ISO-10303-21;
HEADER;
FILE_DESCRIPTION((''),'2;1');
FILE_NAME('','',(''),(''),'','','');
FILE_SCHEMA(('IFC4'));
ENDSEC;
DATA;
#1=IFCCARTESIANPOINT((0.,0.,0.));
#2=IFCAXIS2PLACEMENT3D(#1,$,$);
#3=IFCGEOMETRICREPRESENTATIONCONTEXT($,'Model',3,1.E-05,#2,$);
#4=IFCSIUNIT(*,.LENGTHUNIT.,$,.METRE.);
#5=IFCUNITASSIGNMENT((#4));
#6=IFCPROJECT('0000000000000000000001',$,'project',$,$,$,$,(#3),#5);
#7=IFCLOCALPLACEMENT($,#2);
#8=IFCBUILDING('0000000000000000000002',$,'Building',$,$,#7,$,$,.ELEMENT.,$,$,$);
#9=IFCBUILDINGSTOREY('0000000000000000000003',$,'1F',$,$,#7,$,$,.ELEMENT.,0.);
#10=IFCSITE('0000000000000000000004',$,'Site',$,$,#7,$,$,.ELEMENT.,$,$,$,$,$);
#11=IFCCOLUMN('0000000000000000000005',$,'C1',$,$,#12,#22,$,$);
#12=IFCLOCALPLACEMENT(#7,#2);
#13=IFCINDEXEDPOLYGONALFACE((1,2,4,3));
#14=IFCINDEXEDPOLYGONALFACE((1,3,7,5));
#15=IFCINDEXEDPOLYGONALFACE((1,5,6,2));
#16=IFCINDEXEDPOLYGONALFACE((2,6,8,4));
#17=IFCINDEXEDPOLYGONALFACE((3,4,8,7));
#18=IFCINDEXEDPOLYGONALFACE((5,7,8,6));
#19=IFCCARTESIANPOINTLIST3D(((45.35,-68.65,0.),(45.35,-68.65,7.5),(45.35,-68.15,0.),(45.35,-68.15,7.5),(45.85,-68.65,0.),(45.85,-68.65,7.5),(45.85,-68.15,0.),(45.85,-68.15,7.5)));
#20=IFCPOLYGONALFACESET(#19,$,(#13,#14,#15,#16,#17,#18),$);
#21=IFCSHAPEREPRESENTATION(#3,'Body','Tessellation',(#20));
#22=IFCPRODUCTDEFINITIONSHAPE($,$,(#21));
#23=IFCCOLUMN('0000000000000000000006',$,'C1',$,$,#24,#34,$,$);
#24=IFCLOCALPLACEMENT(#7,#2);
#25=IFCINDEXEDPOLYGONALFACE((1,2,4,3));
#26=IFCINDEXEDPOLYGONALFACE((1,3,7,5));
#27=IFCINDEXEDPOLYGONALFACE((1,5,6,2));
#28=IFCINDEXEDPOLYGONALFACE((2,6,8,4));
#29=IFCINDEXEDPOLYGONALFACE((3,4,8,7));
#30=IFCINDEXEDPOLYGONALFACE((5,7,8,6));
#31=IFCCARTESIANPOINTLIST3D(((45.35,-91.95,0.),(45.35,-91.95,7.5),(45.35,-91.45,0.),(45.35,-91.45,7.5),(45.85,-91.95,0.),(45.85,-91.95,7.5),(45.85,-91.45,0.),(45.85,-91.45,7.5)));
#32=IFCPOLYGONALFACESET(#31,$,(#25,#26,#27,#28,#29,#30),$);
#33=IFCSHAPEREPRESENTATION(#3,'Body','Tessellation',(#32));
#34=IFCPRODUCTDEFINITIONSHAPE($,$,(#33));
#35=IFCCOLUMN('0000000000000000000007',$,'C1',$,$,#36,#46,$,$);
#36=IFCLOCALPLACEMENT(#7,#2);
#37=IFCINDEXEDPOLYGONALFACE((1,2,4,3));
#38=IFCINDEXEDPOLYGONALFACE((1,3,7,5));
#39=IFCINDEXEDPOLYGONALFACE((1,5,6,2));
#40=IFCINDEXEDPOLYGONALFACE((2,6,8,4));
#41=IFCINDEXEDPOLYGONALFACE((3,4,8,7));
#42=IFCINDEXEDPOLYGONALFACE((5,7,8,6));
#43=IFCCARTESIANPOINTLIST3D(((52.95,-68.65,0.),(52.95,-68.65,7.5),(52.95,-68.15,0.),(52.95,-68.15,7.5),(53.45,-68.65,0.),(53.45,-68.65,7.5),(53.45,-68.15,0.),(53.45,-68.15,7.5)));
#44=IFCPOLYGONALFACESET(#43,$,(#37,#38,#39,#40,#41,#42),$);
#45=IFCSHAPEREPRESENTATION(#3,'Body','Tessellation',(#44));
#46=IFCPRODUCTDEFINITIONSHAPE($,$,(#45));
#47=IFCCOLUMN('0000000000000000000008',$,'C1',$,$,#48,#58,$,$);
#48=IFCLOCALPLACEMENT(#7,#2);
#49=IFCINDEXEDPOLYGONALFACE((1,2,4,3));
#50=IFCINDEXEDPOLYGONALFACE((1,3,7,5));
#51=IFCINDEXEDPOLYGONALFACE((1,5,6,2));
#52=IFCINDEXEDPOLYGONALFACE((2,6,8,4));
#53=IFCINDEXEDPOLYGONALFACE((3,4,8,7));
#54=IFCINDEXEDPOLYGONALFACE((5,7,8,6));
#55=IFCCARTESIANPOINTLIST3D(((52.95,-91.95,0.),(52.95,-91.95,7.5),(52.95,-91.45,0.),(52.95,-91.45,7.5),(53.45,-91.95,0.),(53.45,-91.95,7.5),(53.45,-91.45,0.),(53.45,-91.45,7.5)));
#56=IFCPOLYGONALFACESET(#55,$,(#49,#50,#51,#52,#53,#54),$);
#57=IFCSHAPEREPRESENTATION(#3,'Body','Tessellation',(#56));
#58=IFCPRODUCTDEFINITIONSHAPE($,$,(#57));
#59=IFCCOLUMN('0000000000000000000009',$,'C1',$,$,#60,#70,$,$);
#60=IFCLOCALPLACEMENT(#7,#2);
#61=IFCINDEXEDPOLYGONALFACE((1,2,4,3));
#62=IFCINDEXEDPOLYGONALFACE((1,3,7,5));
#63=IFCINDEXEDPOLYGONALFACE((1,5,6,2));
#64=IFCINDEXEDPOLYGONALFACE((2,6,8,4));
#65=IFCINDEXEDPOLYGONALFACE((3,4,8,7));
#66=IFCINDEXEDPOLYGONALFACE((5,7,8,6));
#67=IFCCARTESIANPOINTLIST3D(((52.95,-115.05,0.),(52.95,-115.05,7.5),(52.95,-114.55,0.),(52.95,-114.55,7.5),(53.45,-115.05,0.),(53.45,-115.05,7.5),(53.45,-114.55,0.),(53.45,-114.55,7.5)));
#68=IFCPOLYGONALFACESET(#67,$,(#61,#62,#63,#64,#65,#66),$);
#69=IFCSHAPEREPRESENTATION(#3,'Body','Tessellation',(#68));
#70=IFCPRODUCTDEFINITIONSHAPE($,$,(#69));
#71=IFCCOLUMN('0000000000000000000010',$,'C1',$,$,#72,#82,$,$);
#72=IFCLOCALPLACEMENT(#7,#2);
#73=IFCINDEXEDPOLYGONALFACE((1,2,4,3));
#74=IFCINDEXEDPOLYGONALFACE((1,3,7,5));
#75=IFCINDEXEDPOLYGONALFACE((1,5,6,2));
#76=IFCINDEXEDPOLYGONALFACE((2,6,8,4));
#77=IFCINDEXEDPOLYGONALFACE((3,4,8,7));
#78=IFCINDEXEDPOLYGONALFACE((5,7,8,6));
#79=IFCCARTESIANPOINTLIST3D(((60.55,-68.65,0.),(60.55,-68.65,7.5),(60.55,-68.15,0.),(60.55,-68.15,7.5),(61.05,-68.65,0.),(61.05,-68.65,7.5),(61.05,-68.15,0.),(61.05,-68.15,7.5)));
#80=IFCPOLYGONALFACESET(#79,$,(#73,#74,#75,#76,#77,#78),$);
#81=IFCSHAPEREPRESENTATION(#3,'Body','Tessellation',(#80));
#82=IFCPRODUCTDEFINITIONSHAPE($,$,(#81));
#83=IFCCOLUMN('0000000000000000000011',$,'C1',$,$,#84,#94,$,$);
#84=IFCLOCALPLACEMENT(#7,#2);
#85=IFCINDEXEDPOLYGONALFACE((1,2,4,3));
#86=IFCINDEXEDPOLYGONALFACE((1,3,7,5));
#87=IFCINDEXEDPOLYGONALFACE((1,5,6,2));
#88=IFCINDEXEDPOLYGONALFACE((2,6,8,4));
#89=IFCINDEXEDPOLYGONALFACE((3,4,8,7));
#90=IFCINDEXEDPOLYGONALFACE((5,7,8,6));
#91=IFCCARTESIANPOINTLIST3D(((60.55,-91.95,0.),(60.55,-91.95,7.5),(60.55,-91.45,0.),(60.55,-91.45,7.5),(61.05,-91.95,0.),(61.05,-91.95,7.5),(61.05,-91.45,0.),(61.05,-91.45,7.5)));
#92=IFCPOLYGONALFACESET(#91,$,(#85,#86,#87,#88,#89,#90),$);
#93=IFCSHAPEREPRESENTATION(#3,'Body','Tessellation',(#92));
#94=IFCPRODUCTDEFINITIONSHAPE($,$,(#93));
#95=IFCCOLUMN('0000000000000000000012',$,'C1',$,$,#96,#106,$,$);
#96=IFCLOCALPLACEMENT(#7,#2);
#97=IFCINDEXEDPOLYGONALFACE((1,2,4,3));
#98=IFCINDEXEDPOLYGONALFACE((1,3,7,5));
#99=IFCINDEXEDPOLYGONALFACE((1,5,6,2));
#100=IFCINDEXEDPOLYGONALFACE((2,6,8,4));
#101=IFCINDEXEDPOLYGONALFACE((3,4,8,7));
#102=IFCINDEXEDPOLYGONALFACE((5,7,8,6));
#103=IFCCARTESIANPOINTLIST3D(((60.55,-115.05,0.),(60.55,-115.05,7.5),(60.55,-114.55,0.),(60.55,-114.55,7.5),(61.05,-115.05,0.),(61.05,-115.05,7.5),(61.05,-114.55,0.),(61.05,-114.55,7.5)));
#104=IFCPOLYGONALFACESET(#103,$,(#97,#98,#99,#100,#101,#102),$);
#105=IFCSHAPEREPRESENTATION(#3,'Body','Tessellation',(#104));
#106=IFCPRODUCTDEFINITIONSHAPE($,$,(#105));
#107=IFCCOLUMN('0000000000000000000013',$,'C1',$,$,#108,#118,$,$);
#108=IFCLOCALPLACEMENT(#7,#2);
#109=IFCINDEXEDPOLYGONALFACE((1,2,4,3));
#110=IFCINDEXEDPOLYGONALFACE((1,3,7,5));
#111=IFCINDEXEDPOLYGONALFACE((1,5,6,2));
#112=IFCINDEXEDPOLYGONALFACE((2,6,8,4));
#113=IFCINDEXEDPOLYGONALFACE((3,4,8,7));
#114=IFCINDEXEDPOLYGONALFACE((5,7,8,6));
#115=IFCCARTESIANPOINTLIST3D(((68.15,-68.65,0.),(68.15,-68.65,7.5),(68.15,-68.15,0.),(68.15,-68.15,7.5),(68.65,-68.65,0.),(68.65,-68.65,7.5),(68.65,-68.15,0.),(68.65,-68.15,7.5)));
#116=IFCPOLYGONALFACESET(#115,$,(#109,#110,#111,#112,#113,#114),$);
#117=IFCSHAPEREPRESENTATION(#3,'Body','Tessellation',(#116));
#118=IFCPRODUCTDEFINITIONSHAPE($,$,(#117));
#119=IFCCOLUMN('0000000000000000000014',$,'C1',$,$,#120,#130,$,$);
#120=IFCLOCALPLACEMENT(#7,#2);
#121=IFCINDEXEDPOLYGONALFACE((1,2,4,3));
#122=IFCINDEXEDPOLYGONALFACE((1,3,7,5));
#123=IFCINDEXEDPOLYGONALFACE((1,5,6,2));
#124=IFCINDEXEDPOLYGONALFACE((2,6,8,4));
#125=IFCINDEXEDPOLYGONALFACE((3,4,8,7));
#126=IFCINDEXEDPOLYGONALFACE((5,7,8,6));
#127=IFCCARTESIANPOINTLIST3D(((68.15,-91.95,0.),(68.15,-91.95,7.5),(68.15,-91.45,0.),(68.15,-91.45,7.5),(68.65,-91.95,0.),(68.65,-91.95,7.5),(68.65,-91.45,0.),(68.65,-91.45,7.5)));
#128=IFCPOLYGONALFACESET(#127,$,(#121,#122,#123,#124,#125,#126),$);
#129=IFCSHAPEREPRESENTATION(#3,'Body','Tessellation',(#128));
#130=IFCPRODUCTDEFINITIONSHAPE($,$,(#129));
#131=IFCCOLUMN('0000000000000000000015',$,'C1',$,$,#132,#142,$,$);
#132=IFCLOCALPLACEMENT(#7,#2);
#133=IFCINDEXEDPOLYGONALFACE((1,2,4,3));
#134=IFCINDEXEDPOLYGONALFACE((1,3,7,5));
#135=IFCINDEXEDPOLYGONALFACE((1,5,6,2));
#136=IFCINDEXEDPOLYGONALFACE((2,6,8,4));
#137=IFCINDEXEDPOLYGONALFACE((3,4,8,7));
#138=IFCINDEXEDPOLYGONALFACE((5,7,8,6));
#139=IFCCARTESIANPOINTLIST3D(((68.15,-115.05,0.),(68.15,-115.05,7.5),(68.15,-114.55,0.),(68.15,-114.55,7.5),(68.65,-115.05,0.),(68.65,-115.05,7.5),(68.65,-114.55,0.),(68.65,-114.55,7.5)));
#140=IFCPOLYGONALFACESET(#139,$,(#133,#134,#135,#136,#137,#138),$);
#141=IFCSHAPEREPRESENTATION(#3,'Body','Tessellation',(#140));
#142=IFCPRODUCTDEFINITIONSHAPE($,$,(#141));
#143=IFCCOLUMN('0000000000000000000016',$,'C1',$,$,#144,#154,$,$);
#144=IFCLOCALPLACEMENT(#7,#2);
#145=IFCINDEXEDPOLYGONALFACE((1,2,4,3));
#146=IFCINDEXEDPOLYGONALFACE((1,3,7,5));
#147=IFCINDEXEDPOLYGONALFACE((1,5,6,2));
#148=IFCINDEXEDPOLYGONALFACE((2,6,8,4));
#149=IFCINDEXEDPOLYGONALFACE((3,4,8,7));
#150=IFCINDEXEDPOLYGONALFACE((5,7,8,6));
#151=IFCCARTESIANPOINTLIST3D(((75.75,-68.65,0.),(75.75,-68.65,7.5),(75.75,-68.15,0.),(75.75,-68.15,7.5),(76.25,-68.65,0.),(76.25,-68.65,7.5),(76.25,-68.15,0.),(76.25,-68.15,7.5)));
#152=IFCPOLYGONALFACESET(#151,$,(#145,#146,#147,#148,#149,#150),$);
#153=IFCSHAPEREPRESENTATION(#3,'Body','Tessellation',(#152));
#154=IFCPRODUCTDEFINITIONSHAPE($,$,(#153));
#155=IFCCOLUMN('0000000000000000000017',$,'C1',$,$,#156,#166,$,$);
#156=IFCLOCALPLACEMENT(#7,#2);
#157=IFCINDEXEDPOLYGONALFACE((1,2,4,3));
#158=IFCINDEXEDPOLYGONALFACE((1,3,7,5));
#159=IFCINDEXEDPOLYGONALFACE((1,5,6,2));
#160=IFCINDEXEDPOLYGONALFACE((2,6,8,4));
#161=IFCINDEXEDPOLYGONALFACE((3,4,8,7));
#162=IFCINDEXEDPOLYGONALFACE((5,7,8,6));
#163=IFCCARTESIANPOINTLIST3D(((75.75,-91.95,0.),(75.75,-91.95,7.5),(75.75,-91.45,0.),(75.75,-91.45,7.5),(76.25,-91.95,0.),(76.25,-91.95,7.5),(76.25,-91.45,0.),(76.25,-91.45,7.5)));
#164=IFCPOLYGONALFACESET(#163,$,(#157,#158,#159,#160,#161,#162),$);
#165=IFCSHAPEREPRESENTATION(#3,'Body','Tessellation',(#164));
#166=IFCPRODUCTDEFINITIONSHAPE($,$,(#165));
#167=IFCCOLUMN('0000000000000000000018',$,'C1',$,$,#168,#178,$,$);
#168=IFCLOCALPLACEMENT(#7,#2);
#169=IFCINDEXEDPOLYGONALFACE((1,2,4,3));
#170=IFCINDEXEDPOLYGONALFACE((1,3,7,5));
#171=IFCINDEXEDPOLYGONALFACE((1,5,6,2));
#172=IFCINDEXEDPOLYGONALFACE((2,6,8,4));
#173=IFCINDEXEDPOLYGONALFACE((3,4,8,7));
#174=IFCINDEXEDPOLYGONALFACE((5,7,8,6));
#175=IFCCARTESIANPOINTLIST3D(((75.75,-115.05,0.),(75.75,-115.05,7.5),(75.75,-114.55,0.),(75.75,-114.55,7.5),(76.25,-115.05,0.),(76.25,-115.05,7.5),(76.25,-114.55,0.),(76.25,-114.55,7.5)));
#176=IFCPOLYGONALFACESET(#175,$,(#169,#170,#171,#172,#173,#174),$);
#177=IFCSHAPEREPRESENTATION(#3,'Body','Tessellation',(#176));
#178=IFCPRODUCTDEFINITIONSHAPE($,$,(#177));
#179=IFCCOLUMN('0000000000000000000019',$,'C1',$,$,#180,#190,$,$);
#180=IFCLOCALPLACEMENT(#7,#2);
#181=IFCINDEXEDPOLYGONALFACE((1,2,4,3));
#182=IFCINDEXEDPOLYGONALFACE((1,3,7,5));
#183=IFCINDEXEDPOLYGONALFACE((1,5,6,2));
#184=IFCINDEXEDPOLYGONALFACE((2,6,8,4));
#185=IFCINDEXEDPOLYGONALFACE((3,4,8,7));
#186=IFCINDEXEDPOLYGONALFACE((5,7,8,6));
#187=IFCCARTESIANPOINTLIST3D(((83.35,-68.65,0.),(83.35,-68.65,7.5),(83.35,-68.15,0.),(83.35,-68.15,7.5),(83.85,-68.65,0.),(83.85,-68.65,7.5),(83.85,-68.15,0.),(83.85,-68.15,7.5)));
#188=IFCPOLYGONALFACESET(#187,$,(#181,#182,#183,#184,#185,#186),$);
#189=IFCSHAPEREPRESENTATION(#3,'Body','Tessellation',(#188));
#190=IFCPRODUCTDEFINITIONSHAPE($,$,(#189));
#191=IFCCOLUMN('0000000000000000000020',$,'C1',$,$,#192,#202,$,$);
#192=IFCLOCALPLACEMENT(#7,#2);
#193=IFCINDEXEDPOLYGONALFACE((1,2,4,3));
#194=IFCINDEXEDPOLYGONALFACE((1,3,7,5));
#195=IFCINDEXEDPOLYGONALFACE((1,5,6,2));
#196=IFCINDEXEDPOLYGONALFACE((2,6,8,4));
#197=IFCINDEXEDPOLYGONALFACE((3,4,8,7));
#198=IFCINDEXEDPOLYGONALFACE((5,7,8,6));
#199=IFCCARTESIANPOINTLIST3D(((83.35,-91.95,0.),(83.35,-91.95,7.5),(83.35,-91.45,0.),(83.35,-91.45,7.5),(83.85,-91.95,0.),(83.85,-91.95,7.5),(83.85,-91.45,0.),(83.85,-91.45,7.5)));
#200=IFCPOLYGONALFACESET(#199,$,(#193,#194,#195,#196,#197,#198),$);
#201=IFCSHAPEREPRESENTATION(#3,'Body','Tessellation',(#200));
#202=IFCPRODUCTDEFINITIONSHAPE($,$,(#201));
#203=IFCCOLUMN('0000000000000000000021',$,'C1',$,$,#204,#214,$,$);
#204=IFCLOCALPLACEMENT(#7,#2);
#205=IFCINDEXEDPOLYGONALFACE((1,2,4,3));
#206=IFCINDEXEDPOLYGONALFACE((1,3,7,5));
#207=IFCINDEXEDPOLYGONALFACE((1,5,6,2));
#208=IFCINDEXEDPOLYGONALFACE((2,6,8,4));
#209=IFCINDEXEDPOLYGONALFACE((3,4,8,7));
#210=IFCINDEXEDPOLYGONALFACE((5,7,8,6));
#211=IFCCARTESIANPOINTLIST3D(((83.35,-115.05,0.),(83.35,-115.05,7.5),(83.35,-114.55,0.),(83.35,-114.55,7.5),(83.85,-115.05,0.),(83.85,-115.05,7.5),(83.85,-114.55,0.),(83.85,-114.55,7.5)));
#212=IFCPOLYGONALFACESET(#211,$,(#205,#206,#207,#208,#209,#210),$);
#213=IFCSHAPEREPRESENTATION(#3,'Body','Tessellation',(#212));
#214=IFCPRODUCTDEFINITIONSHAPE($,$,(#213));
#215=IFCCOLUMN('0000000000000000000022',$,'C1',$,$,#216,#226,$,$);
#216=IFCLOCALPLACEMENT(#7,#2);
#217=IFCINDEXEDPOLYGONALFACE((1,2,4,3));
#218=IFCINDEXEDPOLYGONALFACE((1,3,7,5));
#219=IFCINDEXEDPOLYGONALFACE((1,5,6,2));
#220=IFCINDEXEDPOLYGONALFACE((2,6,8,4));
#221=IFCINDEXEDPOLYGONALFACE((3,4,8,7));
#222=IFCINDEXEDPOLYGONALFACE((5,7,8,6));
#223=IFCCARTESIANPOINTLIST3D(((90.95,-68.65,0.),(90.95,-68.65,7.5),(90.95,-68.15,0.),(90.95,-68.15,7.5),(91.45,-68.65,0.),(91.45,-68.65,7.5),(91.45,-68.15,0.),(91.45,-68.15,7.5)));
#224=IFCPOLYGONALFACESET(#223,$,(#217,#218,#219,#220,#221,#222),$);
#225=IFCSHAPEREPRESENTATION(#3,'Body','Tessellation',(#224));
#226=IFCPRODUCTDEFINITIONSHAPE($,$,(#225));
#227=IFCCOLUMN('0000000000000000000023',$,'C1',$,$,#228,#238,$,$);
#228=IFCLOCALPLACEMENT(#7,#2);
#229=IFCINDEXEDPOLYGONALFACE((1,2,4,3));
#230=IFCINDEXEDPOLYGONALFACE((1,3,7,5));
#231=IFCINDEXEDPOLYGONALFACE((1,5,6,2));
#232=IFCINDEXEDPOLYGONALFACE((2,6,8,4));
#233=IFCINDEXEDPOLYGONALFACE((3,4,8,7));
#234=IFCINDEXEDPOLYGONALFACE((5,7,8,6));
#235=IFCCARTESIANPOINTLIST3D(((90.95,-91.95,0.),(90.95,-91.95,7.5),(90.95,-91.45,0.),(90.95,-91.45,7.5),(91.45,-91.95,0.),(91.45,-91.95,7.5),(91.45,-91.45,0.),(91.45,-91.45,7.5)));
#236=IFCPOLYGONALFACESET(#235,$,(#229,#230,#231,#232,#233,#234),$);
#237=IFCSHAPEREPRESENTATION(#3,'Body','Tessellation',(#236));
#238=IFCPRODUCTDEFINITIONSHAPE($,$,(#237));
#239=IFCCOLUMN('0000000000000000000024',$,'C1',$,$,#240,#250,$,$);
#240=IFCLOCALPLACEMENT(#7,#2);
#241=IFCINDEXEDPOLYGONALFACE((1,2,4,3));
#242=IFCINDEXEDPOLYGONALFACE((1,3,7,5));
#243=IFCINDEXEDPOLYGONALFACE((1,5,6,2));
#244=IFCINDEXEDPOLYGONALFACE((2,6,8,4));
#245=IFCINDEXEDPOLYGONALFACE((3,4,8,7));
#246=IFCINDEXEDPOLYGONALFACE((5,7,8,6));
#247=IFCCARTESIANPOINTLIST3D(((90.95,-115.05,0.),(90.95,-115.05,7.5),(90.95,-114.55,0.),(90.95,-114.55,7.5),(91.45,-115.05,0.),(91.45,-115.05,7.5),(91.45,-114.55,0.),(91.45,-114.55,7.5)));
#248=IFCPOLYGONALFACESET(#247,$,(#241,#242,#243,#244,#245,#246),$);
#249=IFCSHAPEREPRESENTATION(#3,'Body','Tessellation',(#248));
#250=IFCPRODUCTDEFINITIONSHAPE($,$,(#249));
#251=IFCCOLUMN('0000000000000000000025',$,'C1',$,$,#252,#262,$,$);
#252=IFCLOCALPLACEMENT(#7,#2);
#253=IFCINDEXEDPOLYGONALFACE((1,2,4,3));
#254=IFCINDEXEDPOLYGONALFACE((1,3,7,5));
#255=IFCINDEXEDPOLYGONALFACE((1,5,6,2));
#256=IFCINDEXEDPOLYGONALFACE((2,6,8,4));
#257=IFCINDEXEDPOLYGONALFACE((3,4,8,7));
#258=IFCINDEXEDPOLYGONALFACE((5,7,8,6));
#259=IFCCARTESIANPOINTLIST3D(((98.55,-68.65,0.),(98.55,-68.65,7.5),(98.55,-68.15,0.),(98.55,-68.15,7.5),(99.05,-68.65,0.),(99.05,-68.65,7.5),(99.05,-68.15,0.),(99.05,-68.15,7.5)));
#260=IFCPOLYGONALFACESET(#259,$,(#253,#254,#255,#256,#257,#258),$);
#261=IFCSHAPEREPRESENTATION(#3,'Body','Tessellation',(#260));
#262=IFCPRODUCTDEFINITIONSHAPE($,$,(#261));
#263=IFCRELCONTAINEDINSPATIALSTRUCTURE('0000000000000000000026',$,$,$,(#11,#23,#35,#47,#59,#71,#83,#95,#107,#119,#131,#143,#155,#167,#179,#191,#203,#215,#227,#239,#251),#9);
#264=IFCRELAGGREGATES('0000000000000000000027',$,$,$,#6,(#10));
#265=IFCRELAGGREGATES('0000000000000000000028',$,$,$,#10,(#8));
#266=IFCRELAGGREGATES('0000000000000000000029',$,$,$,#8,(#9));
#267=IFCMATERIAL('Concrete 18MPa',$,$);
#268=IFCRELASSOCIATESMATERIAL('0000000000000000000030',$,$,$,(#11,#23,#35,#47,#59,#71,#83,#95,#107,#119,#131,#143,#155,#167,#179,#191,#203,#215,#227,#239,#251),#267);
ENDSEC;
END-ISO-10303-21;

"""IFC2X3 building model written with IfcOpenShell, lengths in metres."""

from ifc_helpers import new_model, si_unit, frame, origin, origin_2d, place, context, project, spatial, rectangle, extrude, material, element, save


model = new_model("IFC2X3")

# Units and contexts
model_context = context("Model", 3, precision=1e-05, world=origin())
ifc_project = project(units=[si_unit("LENGTHUNIT", "METRE")], contexts=[model_context])

# Site, building, storey
placement = place(None, origin())
site = spatial("IfcSite", under=ifc_project, at=placement, Name="Site", CompositionType="ELEMENT")
building = spatial("IfcBuilding", under=site, at=placement, Name="Building", CompositionType="ELEMENT")
storey = spatial("IfcBuildingStorey", under=building, at=placement, Name="1F", CompositionType="ELEMENT", Elevation=0.0)

# Columns
ifc_material = material(Name="Concrete 18MPa")
for number, where, name in (
    (1, (45.6, -68.4, 0.0), "C1"),
    (2, (45.6, -91.7, 0.0), "C1"),
    (3, (53.2, -68.4, 0.0), "C1"),
    (4, (53.2, -91.7, 0.0), "C1"),
    (5, (53.2, -114.8, 0.0), "C1"),
    (6, (60.8, -68.4, 0.0), "C1"),
    (7, (60.8, -91.7, 0.0), "C1"),
    (8, (60.8, -114.8, 0.0), "C1"),
    (9, (68.4, -68.4, 0.0), "C1"),
    (10, (68.4, -91.7, 0.0), "C1"),
    (11, (68.4, -114.8, 0.0), "C1"),
    (12, (76.0, -68.4, 0.0), "C1"),
    (13, (76.0, -91.7, 0.0), "C1"),
    (14, (76.0, -114.8, 0.0), "C1"),
    (15, (83.6, -68.4, 0.0), "C1"),
    (16, (83.6, -91.7, 0.0), "C1"),
    (17, (83.6, -114.8, 0.0), "C1"),
    (18, (91.2, -68.4, 0.0), "C1"),
    (19, (91.2, -91.7, 0.0), "C1"),
    (20, (91.2, -114.8, 0.0), "C1"),
    (21, (98.8, -68.4, 0.0), "C1"),
):
    element("IfcColumn", number, at=place(None, frame(where)), inside=storey, material=ifc_material, Name=name, context=model_context, shape_type="SweptSolid", body=[
        extrude(rectangle(XDim=0.5, YDim=0.5, at=origin_2d()), origin(), (0.0, 0.0, 1.0), 7.5),
    ])

save(model, "model.ifc")
